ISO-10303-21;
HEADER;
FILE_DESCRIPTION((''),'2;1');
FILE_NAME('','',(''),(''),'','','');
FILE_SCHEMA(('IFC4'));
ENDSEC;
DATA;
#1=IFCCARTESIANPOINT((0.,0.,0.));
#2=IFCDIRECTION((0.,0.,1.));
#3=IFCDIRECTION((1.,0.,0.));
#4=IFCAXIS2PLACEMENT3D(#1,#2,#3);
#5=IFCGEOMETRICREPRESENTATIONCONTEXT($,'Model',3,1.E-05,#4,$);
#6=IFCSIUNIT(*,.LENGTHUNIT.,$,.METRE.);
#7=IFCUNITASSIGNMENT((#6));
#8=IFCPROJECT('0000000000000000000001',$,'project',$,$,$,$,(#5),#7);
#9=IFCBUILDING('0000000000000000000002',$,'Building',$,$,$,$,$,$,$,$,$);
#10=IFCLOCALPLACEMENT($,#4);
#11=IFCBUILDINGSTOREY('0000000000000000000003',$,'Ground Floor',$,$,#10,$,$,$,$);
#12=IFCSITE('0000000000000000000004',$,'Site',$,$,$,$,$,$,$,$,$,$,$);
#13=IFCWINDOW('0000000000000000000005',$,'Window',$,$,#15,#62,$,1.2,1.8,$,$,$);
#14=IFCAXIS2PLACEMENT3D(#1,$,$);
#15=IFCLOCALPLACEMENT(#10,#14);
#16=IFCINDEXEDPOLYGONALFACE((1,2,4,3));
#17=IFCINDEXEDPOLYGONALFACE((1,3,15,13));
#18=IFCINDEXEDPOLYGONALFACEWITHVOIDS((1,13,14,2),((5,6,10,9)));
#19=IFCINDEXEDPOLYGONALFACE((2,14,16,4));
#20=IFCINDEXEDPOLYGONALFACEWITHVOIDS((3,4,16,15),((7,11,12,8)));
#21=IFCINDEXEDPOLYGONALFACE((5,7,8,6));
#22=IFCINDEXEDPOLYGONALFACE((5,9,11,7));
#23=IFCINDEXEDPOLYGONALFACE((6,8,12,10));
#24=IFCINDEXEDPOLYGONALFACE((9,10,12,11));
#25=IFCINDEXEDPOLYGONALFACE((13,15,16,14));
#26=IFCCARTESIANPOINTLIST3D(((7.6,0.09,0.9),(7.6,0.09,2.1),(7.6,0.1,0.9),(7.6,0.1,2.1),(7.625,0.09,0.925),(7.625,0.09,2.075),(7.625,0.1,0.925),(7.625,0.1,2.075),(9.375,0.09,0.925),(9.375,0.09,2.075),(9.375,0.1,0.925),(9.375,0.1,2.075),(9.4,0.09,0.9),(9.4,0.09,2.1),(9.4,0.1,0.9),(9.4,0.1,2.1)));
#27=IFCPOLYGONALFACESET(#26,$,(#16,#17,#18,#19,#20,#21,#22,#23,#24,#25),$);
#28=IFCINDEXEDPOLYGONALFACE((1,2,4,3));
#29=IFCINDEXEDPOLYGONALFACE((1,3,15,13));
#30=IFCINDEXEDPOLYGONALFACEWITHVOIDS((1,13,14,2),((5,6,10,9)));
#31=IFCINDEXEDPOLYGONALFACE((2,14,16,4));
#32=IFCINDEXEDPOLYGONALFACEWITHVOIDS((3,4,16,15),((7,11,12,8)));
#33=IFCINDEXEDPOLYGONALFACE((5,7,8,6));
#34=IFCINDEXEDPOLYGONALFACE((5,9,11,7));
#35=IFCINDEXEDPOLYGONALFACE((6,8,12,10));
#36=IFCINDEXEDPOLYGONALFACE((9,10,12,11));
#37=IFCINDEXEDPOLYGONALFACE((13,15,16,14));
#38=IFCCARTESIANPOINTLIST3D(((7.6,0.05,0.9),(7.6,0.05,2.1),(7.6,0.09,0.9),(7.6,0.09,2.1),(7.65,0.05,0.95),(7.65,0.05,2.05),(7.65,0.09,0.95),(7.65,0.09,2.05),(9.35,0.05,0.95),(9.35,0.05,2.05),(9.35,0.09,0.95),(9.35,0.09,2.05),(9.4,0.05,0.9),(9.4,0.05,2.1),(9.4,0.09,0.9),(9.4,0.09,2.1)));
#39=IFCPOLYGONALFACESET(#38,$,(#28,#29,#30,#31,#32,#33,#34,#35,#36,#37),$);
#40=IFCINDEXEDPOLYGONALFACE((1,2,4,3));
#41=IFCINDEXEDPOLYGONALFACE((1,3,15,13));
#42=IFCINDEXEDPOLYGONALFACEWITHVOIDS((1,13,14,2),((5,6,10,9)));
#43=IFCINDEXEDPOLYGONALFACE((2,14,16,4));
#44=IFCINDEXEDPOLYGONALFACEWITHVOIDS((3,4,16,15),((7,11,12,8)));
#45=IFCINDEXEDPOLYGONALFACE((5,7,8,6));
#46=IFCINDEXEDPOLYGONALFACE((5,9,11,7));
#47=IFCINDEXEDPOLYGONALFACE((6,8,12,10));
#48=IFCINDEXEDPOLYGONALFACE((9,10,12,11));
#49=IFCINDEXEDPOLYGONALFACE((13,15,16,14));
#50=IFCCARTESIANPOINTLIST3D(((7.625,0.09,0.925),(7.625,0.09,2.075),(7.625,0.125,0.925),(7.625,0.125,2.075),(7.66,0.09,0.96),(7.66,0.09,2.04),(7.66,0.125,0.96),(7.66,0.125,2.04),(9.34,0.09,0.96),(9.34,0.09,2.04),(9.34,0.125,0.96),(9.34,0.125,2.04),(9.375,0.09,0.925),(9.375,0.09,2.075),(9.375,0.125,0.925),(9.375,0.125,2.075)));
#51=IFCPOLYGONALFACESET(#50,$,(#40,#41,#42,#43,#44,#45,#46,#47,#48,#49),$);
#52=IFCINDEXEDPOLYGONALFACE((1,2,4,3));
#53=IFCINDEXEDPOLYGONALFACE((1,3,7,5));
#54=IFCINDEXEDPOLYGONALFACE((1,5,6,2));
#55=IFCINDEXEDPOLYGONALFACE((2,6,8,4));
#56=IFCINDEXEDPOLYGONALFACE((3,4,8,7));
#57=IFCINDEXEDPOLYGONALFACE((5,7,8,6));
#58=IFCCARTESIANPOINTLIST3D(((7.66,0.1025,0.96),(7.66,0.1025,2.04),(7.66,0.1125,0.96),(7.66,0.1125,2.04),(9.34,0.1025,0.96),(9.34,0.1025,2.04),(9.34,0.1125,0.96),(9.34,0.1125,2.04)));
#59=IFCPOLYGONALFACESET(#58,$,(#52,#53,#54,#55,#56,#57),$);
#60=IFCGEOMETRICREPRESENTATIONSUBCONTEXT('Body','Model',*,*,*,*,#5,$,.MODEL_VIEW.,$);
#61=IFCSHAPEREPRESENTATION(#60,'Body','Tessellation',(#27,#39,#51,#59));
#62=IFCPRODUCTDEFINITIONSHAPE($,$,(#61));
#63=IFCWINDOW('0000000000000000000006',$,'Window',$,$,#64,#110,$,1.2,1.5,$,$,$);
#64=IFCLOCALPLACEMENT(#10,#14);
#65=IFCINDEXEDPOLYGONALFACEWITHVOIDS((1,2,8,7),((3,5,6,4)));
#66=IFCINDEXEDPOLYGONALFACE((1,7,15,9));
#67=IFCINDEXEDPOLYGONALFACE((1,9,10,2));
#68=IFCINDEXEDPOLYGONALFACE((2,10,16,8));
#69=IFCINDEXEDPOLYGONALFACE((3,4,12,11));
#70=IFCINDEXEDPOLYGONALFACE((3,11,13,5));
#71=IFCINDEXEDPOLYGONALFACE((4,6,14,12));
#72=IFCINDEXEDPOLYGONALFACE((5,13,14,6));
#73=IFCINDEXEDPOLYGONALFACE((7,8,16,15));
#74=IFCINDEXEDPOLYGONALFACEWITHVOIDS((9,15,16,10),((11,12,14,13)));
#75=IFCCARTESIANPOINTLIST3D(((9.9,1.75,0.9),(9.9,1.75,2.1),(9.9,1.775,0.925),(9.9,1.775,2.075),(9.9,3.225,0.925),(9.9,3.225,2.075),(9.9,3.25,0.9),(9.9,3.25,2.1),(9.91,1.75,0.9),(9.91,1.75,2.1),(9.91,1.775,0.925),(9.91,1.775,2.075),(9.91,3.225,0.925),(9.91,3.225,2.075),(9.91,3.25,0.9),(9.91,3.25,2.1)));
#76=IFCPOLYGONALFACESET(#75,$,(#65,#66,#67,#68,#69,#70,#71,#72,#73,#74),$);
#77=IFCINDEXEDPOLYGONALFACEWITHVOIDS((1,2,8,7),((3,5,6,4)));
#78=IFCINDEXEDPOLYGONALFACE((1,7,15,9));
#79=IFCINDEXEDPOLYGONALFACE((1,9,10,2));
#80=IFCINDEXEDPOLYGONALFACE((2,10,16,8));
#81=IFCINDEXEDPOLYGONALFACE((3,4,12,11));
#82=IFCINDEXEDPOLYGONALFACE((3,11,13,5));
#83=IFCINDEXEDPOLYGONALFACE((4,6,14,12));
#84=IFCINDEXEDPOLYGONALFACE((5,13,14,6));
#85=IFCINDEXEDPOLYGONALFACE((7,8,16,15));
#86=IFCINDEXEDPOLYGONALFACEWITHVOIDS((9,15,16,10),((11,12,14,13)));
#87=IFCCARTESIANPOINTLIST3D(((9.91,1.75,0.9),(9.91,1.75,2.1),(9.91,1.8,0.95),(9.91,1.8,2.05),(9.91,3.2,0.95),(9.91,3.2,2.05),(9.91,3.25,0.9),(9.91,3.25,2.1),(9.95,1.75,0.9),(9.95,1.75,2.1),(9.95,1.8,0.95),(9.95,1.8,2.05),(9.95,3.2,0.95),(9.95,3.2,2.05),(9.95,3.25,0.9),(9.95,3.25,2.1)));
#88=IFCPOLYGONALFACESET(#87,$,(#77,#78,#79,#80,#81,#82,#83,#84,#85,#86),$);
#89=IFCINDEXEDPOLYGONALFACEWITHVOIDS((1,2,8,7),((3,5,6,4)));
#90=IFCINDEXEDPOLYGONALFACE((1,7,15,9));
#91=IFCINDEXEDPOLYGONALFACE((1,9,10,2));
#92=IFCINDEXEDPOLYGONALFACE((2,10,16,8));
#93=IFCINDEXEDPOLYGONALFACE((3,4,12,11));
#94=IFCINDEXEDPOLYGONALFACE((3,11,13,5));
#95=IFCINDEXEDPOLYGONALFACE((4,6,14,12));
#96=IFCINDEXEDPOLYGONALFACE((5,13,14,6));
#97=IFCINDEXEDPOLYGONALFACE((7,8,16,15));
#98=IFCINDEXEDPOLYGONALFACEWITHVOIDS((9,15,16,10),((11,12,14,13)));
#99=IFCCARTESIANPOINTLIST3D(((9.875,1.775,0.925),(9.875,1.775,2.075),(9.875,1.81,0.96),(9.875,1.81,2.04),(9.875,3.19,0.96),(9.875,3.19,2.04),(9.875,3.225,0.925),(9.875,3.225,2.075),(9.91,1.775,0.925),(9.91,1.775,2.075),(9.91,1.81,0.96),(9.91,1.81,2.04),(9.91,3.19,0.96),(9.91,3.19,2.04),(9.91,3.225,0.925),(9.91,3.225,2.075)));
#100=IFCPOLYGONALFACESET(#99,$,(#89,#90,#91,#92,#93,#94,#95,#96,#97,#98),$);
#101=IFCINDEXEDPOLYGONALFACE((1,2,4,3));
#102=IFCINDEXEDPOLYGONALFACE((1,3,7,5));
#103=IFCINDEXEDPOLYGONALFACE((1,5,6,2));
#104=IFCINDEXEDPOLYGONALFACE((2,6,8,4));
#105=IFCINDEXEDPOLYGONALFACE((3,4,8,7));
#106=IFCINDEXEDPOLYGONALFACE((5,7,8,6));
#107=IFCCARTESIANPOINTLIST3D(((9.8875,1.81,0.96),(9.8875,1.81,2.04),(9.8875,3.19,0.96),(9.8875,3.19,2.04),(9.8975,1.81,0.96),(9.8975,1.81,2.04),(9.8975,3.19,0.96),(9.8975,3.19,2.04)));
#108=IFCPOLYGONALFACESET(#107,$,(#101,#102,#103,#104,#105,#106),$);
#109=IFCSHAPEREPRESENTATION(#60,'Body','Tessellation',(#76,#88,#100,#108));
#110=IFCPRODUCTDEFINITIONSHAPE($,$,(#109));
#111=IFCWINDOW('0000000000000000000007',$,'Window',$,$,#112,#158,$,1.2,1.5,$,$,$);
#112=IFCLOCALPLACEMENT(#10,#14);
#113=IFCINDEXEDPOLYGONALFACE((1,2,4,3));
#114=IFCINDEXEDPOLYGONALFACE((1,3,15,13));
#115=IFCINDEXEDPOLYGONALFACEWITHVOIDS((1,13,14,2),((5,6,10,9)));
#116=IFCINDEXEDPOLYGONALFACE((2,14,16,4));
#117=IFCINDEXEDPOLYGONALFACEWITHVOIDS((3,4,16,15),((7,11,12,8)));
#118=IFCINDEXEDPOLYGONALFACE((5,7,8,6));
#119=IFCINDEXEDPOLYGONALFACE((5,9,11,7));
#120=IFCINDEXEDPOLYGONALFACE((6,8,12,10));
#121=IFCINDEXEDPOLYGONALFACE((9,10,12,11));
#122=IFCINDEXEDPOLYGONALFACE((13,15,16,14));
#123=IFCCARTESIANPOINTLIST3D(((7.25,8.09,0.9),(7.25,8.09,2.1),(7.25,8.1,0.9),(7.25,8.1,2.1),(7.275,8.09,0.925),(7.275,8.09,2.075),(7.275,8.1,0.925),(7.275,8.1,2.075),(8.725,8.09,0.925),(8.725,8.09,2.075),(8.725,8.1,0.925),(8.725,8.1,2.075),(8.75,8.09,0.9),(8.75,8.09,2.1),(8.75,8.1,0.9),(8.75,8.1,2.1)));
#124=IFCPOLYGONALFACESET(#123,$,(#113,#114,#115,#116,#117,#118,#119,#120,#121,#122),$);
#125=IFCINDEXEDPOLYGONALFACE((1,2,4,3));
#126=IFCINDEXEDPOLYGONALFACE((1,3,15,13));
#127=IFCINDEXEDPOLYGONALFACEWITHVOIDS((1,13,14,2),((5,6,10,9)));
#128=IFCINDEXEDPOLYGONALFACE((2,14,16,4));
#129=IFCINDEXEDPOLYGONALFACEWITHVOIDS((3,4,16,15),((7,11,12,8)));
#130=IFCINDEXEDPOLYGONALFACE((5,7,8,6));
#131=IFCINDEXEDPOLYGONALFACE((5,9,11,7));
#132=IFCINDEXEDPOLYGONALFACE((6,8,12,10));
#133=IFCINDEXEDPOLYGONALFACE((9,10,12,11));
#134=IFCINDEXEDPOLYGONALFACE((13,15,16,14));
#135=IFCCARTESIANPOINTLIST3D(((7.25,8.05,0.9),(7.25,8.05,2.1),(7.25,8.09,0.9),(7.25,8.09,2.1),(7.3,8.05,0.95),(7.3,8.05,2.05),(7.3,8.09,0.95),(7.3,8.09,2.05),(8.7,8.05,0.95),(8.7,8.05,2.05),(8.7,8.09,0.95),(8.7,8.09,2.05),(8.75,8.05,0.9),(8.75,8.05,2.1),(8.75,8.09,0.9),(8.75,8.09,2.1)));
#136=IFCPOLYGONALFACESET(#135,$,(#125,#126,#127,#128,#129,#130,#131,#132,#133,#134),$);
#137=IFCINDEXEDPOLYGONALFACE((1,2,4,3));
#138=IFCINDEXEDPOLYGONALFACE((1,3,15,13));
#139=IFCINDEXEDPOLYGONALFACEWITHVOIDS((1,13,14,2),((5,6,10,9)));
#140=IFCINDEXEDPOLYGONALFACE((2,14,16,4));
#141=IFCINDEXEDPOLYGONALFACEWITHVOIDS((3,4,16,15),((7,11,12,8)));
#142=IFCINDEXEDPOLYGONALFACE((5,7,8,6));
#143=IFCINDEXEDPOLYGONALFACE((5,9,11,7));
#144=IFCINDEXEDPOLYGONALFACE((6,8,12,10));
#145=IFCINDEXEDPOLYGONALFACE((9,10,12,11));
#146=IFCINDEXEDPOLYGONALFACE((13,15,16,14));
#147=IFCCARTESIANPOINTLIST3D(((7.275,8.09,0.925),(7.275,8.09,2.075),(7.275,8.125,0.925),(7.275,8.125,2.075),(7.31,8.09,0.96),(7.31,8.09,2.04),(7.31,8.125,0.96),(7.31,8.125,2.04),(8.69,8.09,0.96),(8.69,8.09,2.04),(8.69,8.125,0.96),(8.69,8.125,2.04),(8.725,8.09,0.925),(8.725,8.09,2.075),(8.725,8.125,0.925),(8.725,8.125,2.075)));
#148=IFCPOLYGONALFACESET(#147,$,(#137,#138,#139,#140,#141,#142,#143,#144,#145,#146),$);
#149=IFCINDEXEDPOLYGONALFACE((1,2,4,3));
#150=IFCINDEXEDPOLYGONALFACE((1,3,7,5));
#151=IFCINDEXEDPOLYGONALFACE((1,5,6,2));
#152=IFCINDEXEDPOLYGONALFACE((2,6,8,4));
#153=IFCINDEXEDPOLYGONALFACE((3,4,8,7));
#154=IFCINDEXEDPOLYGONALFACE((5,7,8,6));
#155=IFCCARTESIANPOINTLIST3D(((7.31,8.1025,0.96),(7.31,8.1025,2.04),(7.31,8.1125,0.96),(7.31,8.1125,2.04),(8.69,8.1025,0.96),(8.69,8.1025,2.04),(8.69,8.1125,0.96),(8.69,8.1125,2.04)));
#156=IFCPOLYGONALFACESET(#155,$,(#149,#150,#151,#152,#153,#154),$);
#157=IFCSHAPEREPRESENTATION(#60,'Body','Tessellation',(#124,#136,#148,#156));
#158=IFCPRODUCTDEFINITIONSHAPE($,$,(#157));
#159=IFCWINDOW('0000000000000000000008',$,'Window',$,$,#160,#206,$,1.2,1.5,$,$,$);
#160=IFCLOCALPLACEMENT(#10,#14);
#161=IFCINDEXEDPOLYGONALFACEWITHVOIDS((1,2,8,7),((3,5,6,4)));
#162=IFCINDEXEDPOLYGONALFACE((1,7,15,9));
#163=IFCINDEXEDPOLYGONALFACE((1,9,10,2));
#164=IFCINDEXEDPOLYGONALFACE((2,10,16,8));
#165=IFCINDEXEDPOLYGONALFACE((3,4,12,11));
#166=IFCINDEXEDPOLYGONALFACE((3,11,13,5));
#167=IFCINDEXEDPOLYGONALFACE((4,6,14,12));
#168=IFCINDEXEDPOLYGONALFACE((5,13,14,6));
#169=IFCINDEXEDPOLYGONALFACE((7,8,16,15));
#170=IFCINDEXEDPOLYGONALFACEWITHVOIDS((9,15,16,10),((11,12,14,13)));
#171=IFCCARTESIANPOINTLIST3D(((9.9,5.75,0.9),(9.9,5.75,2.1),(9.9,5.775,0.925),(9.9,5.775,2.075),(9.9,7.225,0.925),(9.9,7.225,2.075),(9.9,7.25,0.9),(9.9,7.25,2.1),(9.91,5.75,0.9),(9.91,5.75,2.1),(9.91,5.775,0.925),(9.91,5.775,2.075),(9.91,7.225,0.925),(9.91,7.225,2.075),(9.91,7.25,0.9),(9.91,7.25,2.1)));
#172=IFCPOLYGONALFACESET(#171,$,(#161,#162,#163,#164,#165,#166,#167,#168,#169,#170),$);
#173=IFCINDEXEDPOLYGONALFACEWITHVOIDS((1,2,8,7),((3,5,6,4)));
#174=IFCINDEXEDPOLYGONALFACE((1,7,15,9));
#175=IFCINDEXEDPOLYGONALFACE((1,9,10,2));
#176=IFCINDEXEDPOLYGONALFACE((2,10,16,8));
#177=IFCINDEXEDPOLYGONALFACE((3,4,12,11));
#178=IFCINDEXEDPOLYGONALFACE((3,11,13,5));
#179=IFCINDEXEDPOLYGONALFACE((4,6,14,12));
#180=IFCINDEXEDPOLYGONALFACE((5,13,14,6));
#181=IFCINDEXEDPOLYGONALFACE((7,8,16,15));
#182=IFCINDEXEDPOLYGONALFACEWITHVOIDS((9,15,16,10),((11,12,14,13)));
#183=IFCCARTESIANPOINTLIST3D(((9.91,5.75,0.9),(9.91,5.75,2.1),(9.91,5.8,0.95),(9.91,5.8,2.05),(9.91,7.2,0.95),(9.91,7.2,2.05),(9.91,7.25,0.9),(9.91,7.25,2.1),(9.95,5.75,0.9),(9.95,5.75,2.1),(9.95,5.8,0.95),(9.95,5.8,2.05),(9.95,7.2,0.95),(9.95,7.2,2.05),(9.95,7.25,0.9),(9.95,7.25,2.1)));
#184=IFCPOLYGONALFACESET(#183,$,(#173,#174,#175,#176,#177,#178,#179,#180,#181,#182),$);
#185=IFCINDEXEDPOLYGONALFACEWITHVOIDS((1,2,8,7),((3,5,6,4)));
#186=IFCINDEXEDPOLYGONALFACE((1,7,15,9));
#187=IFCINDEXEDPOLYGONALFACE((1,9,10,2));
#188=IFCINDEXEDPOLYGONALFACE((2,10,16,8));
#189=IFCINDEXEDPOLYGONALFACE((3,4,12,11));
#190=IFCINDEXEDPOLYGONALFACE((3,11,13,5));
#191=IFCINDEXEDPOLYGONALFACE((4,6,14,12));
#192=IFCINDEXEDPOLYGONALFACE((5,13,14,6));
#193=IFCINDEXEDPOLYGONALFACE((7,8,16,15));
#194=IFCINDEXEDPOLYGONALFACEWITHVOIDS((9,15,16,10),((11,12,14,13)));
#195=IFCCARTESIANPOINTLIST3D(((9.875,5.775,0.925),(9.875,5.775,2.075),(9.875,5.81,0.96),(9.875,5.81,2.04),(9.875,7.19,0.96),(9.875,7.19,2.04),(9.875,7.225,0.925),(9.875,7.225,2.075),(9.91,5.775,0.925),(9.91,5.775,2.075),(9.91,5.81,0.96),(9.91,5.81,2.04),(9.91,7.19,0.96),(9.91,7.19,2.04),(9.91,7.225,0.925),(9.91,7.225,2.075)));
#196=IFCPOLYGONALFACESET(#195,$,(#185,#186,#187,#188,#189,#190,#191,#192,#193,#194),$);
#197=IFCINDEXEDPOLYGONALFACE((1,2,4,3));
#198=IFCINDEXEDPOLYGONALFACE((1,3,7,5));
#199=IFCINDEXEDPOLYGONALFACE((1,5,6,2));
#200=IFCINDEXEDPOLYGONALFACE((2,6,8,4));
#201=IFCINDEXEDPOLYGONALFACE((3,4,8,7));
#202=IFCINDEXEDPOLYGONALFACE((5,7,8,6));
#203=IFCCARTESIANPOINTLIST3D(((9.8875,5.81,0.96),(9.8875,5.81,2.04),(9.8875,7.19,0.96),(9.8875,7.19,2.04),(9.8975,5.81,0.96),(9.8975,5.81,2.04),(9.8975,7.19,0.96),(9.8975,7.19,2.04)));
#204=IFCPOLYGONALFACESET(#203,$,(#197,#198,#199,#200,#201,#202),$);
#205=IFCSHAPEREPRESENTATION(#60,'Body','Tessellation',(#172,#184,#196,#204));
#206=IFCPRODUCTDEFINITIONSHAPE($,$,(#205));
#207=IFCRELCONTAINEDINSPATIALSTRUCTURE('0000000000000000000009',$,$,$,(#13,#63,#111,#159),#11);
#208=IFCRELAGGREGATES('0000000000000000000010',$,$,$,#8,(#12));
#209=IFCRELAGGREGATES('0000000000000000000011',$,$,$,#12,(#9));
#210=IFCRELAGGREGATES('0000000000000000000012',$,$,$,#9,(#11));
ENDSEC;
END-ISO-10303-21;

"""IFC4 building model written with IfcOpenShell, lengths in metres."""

from ifc_helpers import new_model, si_unit, frame, origin_with_axes, place, context, subcontext, project, spatial, line, indexed_curve, outline, extrude, element, save


model = new_model("IFC4")

# Units and contexts
model_context = context("Model", 3, precision=1e-05, world=origin_with_axes())
body_context = subcontext(model_context, "Body", "Model", "MODEL_VIEW")
ifc_project = project(units=[si_unit("LENGTHUNIT", "METRE")], contexts=[model_context])

# Site, building, storey
site = spatial("IfcSite", under=ifc_project, Name="Site")
building = spatial("IfcBuilding", under=site, Name="Building")
storey_placement = place(None, origin_with_axes())
storey = spatial("IfcBuildingStorey", under=building, at=storey_placement, Name="Ground Floor")

# Windows
window_1_placement = place(storey_placement, frame((7.6, 0.0, 0.9), z_axis=(0.0, 0.0, 1.0), x_axis=(1.0, 0.0, 0.0)))
element("IfcWindow", 1, at=window_1_placement, inside=storey, Name="Window", OverallHeight=1.2, OverallWidth=1.8, context=body_context, shape_type="SweptSolid", body=[
    extrude(outline(indexed_curve([(0.0, 0.0), (1.8, 0.0), (1.8, 1.2), (0.0, 1.2)], segments=[line(1, 2, 3, 4, 1)]), holes=[indexed_curve([(0.025, 0.025), (1.775, 0.025), (1.775, 1.175), (0.025, 1.175)], segments=[line(1, 2, 3, 4, 1)])]), frame((0.0, 0.09, 0.0), z_axis=(0.0, -1.0, 0.0), x_axis=(1.0, 0.0, 0.0)), (0.0, 0.0, -1.0), 0.01),
    extrude(outline(indexed_curve([(0.0, 0.0), (1.8, 0.0), (1.8, 1.2), (0.0, 1.2)], segments=[line(1, 2, 3, 4, 1)]), holes=[indexed_curve([(0.05, 0.05), (1.75, 0.05), (1.75, 1.15), (0.05, 1.15)], segments=[line(1, 2, 3, 4, 1)])]), frame((0.0, 0.05, 0.0), z_axis=(0.0, -1.0, 0.0), x_axis=(1.0, 0.0, 0.0)), (0.0, 0.0, -1.0), 0.04),
    extrude(outline(indexed_curve([(0.0, 0.0), (1.75, 0.0), (1.75, 1.15), (0.0, 1.15)], segments=[line(1, 2, 3, 4, 1)]), holes=[indexed_curve([(0.035, 0.035), (1.715, 0.035), (1.715, 1.115), (0.035, 1.115)], segments=[line(1, 2, 3, 4, 1)])]), frame((0.025, 0.09, 0.025), z_axis=(0.0, -1.0, 0.0), x_axis=(1.0, 0.0, 0.0)), (0.0, 0.0, -1.0), 0.035),
    extrude(outline(indexed_curve([(0.035, 0.035), (1.715, 0.035), (1.715, 1.115), (0.035, 1.115)], segments=[line(1, 2, 3, 4, 1)])), frame((0.025, 0.1025, 0.025), z_axis=(0.0, -1.0, 0.0), x_axis=(1.0, 0.0, 0.0)), (0.0, 0.0, -1.0), 0.01),
])
for number, where, z_axis, x_axis, name in (
    (2, (10.0, 1.75, 0.9), (0.0, 0.0, 1.0), (0.0, 1.0, 0.0), "Window"),
    (3, (7.25, 8.0, 0.9), (0.0, 0.0, 1.0), (1.0, 0.0, 0.0), "Window"),
    (4, (10.0, 5.75, 0.9), (0.0, 0.0, 1.0), (0.0, 1.0, 0.0), "Window"),
):
    element("IfcWindow", number, at=place(storey_placement, frame(where, z_axis=z_axis, x_axis=x_axis)), inside=storey, Name=name, OverallHeight=1.2, OverallWidth=1.5, context=body_context, shape_type="SweptSolid", body=[
        extrude(outline(indexed_curve([(0.0, 0.0), (1.5, 0.0), (1.5, 1.2), (0.0, 1.2)], segments=[line(1, 2, 3, 4, 1)]), holes=[indexed_curve([(0.025, 0.025), (1.475, 0.025), (1.475, 1.175), (0.025, 1.175)], segments=[line(1, 2, 3, 4, 1)])]), frame((0.0, 0.09, 0.0), z_axis=(0.0, -1.0, 0.0), x_axis=(1.0, 0.0, 0.0)), (0.0, 0.0, -1.0), 0.01),
        extrude(outline(indexed_curve([(0.0, 0.0), (1.5, 0.0), (1.5, 1.2), (0.0, 1.2)], segments=[line(1, 2, 3, 4, 1)]), holes=[indexed_curve([(0.05, 0.05), (1.45, 0.05), (1.45, 1.15), (0.05, 1.15)], segments=[line(1, 2, 3, 4, 1)])]), frame((0.0, 0.05, 0.0), z_axis=(0.0, -1.0, 0.0), x_axis=(1.0, 0.0, 0.0)), (0.0, 0.0, -1.0), 0.04),
        extrude(outline(indexed_curve([(0.0, 0.0), (1.45, 0.0), (1.45, 1.15), (0.0, 1.15)], segments=[line(1, 2, 3, 4, 1)]), holes=[indexed_curve([(0.035, 0.035), (1.415, 0.035), (1.415, 1.115), (0.035, 1.115)], segments=[line(1, 2, 3, 4, 1)])]), frame((0.025, 0.09, 0.025), z_axis=(0.0, -1.0, 0.0), x_axis=(1.0, 0.0, 0.0)), (0.0, 0.0, -1.0), 0.035),
        extrude(outline(indexed_curve([(0.035, 0.035), (1.415, 0.035), (1.415, 1.115), (0.035, 1.115)], segments=[line(1, 2, 3, 4, 1)])), frame((0.025, 0.1025, 0.025), z_axis=(0.0, -1.0, 0.0), x_axis=(1.0, 0.0, 0.0)), (0.0, 0.0, -1.0), 0.01),
    ])

save(model, "model.ifc")
